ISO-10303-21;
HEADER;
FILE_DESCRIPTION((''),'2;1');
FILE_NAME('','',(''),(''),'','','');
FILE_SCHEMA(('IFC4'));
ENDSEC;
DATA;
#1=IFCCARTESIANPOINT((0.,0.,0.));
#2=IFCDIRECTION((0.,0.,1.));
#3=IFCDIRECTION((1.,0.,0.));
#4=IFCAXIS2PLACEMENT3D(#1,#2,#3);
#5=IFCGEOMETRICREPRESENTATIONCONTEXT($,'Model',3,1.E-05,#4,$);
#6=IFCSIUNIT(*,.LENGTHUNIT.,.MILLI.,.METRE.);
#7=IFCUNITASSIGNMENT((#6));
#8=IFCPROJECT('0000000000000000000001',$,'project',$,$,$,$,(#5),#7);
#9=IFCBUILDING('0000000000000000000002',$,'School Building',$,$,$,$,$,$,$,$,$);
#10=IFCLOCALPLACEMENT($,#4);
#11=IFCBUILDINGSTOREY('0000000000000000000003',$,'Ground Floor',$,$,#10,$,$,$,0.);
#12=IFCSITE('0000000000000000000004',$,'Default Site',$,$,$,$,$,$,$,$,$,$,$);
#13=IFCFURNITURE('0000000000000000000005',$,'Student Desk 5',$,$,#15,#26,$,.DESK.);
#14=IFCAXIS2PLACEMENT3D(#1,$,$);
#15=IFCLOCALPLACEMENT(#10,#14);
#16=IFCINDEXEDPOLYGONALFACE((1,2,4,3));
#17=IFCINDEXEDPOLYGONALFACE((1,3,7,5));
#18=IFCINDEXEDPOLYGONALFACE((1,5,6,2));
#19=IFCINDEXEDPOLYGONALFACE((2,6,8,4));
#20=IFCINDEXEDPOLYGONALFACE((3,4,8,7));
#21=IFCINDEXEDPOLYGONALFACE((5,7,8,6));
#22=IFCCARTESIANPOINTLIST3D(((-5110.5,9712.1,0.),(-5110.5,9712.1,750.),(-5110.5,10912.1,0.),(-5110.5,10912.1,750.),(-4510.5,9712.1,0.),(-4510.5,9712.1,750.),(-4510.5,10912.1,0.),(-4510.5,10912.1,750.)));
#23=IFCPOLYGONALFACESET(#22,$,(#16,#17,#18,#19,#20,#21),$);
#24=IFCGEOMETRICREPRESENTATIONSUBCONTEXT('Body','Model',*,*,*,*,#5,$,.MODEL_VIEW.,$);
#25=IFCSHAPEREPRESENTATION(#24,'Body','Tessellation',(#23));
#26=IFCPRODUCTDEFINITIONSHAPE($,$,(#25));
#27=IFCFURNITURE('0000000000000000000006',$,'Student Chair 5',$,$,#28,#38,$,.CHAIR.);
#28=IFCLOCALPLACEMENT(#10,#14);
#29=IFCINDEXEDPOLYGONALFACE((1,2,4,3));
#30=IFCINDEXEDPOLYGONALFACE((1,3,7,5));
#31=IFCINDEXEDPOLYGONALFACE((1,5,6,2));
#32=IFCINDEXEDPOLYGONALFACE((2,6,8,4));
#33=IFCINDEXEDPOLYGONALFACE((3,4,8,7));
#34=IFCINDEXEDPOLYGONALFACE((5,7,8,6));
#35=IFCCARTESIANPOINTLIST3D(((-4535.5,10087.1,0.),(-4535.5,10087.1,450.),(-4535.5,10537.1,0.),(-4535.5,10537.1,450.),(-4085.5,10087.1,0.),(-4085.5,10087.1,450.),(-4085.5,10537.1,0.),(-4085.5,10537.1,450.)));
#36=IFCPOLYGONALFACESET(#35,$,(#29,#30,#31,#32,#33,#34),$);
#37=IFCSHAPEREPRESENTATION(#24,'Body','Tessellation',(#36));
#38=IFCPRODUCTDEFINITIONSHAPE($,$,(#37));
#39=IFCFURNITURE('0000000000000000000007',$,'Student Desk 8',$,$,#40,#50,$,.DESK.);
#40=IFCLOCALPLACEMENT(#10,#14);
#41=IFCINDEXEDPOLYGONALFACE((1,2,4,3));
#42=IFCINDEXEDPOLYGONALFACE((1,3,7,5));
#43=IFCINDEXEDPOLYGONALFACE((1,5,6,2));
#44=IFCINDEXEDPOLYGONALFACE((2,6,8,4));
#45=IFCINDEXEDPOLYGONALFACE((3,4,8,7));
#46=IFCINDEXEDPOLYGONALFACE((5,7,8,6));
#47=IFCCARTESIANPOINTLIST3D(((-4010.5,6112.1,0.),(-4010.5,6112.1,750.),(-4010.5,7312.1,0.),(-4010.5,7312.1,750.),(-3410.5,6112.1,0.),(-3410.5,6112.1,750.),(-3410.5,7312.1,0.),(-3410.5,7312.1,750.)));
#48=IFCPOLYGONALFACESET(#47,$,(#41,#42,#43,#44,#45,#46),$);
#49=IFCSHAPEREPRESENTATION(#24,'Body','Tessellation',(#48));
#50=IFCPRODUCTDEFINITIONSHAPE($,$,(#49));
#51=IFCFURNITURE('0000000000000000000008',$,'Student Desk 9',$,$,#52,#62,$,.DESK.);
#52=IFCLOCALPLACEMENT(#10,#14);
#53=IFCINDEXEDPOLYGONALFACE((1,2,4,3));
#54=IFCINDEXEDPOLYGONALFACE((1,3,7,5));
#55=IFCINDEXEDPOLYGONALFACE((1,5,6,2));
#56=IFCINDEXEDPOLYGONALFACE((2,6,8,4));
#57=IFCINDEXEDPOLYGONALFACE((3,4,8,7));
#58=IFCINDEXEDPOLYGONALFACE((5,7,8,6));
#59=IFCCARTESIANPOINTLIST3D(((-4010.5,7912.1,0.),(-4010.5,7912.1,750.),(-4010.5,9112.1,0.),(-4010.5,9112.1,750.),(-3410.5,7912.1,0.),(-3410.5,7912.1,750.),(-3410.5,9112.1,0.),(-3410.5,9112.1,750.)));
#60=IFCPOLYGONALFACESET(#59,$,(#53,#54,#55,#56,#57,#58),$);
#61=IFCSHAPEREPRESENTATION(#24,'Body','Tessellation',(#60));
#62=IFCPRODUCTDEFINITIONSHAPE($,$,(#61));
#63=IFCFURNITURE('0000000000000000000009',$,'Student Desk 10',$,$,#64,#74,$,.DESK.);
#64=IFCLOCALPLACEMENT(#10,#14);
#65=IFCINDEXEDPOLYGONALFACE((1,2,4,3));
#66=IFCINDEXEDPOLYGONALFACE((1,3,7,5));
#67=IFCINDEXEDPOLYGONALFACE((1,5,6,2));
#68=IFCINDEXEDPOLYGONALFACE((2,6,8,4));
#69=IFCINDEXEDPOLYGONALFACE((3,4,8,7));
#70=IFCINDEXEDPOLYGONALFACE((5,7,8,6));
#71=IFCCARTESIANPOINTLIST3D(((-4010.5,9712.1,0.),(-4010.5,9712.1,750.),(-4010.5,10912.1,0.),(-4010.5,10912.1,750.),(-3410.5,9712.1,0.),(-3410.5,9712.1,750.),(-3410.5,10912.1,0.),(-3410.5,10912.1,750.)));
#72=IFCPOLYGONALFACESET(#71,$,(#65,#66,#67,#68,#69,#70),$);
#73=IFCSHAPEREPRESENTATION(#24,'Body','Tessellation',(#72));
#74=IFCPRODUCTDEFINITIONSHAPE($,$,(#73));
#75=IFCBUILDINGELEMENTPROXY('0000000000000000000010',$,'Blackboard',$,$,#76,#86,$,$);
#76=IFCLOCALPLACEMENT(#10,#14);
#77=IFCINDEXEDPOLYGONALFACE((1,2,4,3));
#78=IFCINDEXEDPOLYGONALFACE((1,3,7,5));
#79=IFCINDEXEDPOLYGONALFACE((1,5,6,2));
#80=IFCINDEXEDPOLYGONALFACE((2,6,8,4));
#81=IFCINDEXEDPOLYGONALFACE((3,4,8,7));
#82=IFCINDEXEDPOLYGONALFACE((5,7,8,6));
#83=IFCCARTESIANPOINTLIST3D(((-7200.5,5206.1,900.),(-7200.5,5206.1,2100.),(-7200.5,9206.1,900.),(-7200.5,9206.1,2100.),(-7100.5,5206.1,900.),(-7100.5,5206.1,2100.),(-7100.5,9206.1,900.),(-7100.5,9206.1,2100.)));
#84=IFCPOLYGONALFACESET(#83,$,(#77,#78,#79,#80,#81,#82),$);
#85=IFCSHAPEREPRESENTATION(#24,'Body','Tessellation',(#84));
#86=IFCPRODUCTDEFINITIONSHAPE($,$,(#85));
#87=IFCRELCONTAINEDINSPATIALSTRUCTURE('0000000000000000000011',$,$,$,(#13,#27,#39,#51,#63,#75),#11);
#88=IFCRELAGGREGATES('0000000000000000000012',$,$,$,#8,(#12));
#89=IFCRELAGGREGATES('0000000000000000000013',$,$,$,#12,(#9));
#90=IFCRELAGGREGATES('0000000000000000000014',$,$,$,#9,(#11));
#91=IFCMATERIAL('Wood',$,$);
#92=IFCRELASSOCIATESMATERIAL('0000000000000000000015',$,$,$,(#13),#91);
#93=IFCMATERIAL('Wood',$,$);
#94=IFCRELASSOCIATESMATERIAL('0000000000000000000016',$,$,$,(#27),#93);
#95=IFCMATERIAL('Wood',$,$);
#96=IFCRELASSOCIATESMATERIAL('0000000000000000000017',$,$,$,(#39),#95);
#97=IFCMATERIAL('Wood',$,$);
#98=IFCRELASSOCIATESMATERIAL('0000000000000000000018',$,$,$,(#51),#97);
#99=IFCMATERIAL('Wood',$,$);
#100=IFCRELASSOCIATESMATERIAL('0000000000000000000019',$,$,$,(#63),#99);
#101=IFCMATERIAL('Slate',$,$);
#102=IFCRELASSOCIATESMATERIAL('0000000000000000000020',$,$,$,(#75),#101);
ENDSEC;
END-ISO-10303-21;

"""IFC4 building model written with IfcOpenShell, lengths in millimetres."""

from ifc_helpers import new_model, si_unit, frame, origin_with_axes, origin_2d, place, context, subcontext, project, spatial, rectangle, extrude, material, element, save


model = new_model("IFC4")

# Units and contexts
model_context = context("Model", 3, precision=1e-05, world=origin_with_axes())
body_context = subcontext(model_context, "Body", "Model", "MODEL_VIEW")
ifc_project = project(units=[si_unit("LENGTHUNIT", "METRE", prefix="MILLI")], contexts=[model_context])

# Site, building, storey
site = spatial("IfcSite", under=ifc_project, Name="Default Site")
building = spatial("IfcBuilding", under=site, Name="School Building")
storey_placement = place(None, origin_with_axes())
storey = spatial("IfcBuildingStorey", under=building, at=storey_placement, Name="Ground Floor", Elevation=0.0)

# Furniture
ifc_material_1 = material(Name="Wood")
furniture_1_placement = place(storey_placement, frame((-4810.5, 10312.1, 0.0), z_axis=(0.0, 0.0, 1.0), x_axis=(0.0, 1.0, 0.0)))
element("IfcFurniture", 1, at=furniture_1_placement, inside=storey, material=ifc_material_1, Name="Student Desk 5", PredefinedType="DESK", context=body_context, shape_type="SweptSolid", body=[
    extrude(rectangle(XDim=1200.0, YDim=600.0, at=origin_2d()), origin_with_axes(), (0.0, 0.0, 1.0), 750.0),
])
ifc_material_2 = material(Name="Wood")
furniture_2_placement = place(storey_placement, frame((-4310.5, 10312.1, 0.0), z_axis=(0.0, 0.0, 1.0), x_axis=(1.0, 0.0, 0.0)))
element("IfcFurniture", 2, at=furniture_2_placement, inside=storey, material=ifc_material_2, Name="Student Chair 5", PredefinedType="CHAIR", context=body_context, shape_type="SweptSolid", body=[
    extrude(rectangle(XDim=450.0, YDim=450.0, at=origin_2d()), origin_with_axes(), (0.0, 0.0, 1.0), 450.0),
])
ifc_material_3 = material(Name="Wood")
furniture_3_placement = place(storey_placement, frame((-3710.5, 6712.1, 0.0), z_axis=(0.0, 0.0, 1.0), x_axis=(0.0, 1.0, 0.0)))
element("IfcFurniture", 3, at=furniture_3_placement, inside=storey, material=ifc_material_3, Name="Student Desk 8", PredefinedType="DESK", context=body_context, shape_type="SweptSolid", body=[
    extrude(rectangle(XDim=1200.0, YDim=600.0, at=origin_2d()), origin_with_axes(), (0.0, 0.0, 1.0), 750.0),
])
ifc_material_4 = material(Name="Wood")
furniture_4_placement = place(storey_placement, frame((-3710.5, 8512.1, 0.0), z_axis=(0.0, 0.0, 1.0), x_axis=(0.0, 1.0, 0.0)))
element("IfcFurniture", 4, at=furniture_4_placement, inside=storey, material=ifc_material_4, Name="Student Desk 9", PredefinedType="DESK", context=body_context, shape_type="SweptSolid", body=[
    extrude(rectangle(XDim=1200.0, YDim=600.0, at=origin_2d()), origin_with_axes(), (0.0, 0.0, 1.0), 750.0),
])
ifc_material_5 = material(Name="Wood")
furniture_5_placement = place(storey_placement, frame((-3710.5, 10312.1, 0.0), z_axis=(0.0, 0.0, 1.0), x_axis=(0.0, 1.0, 0.0)))
element("IfcFurniture", 5, at=furniture_5_placement, inside=storey, material=ifc_material_5, Name="Student Desk 10", PredefinedType="DESK", context=body_context, shape_type="SweptSolid", body=[
    extrude(rectangle(XDim=1200.0, YDim=600.0, at=origin_2d()), origin_with_axes(), (0.0, 0.0, 1.0), 750.0),
])

# Building element proxy
ifc_material_6 = material(Name="Slate")
proxy_placement = place(storey_placement, frame((-7150.5, 7206.1, 900.0), z_axis=(0.0, 0.0, 1.0), x_axis=(1.0, 0.0, 0.0)))
element("IfcBuildingElementProxy", 6, at=proxy_placement, inside=storey, material=ifc_material_6, Name="Blackboard", context=body_context, shape_type="SweptSolid", body=[
    extrude(rectangle(XDim=100.0, YDim=4000.0, at=origin_2d()), origin_with_axes(), (0.0, 0.0, 1.0), 1200.0),
])

save(model, "model.ifc")
